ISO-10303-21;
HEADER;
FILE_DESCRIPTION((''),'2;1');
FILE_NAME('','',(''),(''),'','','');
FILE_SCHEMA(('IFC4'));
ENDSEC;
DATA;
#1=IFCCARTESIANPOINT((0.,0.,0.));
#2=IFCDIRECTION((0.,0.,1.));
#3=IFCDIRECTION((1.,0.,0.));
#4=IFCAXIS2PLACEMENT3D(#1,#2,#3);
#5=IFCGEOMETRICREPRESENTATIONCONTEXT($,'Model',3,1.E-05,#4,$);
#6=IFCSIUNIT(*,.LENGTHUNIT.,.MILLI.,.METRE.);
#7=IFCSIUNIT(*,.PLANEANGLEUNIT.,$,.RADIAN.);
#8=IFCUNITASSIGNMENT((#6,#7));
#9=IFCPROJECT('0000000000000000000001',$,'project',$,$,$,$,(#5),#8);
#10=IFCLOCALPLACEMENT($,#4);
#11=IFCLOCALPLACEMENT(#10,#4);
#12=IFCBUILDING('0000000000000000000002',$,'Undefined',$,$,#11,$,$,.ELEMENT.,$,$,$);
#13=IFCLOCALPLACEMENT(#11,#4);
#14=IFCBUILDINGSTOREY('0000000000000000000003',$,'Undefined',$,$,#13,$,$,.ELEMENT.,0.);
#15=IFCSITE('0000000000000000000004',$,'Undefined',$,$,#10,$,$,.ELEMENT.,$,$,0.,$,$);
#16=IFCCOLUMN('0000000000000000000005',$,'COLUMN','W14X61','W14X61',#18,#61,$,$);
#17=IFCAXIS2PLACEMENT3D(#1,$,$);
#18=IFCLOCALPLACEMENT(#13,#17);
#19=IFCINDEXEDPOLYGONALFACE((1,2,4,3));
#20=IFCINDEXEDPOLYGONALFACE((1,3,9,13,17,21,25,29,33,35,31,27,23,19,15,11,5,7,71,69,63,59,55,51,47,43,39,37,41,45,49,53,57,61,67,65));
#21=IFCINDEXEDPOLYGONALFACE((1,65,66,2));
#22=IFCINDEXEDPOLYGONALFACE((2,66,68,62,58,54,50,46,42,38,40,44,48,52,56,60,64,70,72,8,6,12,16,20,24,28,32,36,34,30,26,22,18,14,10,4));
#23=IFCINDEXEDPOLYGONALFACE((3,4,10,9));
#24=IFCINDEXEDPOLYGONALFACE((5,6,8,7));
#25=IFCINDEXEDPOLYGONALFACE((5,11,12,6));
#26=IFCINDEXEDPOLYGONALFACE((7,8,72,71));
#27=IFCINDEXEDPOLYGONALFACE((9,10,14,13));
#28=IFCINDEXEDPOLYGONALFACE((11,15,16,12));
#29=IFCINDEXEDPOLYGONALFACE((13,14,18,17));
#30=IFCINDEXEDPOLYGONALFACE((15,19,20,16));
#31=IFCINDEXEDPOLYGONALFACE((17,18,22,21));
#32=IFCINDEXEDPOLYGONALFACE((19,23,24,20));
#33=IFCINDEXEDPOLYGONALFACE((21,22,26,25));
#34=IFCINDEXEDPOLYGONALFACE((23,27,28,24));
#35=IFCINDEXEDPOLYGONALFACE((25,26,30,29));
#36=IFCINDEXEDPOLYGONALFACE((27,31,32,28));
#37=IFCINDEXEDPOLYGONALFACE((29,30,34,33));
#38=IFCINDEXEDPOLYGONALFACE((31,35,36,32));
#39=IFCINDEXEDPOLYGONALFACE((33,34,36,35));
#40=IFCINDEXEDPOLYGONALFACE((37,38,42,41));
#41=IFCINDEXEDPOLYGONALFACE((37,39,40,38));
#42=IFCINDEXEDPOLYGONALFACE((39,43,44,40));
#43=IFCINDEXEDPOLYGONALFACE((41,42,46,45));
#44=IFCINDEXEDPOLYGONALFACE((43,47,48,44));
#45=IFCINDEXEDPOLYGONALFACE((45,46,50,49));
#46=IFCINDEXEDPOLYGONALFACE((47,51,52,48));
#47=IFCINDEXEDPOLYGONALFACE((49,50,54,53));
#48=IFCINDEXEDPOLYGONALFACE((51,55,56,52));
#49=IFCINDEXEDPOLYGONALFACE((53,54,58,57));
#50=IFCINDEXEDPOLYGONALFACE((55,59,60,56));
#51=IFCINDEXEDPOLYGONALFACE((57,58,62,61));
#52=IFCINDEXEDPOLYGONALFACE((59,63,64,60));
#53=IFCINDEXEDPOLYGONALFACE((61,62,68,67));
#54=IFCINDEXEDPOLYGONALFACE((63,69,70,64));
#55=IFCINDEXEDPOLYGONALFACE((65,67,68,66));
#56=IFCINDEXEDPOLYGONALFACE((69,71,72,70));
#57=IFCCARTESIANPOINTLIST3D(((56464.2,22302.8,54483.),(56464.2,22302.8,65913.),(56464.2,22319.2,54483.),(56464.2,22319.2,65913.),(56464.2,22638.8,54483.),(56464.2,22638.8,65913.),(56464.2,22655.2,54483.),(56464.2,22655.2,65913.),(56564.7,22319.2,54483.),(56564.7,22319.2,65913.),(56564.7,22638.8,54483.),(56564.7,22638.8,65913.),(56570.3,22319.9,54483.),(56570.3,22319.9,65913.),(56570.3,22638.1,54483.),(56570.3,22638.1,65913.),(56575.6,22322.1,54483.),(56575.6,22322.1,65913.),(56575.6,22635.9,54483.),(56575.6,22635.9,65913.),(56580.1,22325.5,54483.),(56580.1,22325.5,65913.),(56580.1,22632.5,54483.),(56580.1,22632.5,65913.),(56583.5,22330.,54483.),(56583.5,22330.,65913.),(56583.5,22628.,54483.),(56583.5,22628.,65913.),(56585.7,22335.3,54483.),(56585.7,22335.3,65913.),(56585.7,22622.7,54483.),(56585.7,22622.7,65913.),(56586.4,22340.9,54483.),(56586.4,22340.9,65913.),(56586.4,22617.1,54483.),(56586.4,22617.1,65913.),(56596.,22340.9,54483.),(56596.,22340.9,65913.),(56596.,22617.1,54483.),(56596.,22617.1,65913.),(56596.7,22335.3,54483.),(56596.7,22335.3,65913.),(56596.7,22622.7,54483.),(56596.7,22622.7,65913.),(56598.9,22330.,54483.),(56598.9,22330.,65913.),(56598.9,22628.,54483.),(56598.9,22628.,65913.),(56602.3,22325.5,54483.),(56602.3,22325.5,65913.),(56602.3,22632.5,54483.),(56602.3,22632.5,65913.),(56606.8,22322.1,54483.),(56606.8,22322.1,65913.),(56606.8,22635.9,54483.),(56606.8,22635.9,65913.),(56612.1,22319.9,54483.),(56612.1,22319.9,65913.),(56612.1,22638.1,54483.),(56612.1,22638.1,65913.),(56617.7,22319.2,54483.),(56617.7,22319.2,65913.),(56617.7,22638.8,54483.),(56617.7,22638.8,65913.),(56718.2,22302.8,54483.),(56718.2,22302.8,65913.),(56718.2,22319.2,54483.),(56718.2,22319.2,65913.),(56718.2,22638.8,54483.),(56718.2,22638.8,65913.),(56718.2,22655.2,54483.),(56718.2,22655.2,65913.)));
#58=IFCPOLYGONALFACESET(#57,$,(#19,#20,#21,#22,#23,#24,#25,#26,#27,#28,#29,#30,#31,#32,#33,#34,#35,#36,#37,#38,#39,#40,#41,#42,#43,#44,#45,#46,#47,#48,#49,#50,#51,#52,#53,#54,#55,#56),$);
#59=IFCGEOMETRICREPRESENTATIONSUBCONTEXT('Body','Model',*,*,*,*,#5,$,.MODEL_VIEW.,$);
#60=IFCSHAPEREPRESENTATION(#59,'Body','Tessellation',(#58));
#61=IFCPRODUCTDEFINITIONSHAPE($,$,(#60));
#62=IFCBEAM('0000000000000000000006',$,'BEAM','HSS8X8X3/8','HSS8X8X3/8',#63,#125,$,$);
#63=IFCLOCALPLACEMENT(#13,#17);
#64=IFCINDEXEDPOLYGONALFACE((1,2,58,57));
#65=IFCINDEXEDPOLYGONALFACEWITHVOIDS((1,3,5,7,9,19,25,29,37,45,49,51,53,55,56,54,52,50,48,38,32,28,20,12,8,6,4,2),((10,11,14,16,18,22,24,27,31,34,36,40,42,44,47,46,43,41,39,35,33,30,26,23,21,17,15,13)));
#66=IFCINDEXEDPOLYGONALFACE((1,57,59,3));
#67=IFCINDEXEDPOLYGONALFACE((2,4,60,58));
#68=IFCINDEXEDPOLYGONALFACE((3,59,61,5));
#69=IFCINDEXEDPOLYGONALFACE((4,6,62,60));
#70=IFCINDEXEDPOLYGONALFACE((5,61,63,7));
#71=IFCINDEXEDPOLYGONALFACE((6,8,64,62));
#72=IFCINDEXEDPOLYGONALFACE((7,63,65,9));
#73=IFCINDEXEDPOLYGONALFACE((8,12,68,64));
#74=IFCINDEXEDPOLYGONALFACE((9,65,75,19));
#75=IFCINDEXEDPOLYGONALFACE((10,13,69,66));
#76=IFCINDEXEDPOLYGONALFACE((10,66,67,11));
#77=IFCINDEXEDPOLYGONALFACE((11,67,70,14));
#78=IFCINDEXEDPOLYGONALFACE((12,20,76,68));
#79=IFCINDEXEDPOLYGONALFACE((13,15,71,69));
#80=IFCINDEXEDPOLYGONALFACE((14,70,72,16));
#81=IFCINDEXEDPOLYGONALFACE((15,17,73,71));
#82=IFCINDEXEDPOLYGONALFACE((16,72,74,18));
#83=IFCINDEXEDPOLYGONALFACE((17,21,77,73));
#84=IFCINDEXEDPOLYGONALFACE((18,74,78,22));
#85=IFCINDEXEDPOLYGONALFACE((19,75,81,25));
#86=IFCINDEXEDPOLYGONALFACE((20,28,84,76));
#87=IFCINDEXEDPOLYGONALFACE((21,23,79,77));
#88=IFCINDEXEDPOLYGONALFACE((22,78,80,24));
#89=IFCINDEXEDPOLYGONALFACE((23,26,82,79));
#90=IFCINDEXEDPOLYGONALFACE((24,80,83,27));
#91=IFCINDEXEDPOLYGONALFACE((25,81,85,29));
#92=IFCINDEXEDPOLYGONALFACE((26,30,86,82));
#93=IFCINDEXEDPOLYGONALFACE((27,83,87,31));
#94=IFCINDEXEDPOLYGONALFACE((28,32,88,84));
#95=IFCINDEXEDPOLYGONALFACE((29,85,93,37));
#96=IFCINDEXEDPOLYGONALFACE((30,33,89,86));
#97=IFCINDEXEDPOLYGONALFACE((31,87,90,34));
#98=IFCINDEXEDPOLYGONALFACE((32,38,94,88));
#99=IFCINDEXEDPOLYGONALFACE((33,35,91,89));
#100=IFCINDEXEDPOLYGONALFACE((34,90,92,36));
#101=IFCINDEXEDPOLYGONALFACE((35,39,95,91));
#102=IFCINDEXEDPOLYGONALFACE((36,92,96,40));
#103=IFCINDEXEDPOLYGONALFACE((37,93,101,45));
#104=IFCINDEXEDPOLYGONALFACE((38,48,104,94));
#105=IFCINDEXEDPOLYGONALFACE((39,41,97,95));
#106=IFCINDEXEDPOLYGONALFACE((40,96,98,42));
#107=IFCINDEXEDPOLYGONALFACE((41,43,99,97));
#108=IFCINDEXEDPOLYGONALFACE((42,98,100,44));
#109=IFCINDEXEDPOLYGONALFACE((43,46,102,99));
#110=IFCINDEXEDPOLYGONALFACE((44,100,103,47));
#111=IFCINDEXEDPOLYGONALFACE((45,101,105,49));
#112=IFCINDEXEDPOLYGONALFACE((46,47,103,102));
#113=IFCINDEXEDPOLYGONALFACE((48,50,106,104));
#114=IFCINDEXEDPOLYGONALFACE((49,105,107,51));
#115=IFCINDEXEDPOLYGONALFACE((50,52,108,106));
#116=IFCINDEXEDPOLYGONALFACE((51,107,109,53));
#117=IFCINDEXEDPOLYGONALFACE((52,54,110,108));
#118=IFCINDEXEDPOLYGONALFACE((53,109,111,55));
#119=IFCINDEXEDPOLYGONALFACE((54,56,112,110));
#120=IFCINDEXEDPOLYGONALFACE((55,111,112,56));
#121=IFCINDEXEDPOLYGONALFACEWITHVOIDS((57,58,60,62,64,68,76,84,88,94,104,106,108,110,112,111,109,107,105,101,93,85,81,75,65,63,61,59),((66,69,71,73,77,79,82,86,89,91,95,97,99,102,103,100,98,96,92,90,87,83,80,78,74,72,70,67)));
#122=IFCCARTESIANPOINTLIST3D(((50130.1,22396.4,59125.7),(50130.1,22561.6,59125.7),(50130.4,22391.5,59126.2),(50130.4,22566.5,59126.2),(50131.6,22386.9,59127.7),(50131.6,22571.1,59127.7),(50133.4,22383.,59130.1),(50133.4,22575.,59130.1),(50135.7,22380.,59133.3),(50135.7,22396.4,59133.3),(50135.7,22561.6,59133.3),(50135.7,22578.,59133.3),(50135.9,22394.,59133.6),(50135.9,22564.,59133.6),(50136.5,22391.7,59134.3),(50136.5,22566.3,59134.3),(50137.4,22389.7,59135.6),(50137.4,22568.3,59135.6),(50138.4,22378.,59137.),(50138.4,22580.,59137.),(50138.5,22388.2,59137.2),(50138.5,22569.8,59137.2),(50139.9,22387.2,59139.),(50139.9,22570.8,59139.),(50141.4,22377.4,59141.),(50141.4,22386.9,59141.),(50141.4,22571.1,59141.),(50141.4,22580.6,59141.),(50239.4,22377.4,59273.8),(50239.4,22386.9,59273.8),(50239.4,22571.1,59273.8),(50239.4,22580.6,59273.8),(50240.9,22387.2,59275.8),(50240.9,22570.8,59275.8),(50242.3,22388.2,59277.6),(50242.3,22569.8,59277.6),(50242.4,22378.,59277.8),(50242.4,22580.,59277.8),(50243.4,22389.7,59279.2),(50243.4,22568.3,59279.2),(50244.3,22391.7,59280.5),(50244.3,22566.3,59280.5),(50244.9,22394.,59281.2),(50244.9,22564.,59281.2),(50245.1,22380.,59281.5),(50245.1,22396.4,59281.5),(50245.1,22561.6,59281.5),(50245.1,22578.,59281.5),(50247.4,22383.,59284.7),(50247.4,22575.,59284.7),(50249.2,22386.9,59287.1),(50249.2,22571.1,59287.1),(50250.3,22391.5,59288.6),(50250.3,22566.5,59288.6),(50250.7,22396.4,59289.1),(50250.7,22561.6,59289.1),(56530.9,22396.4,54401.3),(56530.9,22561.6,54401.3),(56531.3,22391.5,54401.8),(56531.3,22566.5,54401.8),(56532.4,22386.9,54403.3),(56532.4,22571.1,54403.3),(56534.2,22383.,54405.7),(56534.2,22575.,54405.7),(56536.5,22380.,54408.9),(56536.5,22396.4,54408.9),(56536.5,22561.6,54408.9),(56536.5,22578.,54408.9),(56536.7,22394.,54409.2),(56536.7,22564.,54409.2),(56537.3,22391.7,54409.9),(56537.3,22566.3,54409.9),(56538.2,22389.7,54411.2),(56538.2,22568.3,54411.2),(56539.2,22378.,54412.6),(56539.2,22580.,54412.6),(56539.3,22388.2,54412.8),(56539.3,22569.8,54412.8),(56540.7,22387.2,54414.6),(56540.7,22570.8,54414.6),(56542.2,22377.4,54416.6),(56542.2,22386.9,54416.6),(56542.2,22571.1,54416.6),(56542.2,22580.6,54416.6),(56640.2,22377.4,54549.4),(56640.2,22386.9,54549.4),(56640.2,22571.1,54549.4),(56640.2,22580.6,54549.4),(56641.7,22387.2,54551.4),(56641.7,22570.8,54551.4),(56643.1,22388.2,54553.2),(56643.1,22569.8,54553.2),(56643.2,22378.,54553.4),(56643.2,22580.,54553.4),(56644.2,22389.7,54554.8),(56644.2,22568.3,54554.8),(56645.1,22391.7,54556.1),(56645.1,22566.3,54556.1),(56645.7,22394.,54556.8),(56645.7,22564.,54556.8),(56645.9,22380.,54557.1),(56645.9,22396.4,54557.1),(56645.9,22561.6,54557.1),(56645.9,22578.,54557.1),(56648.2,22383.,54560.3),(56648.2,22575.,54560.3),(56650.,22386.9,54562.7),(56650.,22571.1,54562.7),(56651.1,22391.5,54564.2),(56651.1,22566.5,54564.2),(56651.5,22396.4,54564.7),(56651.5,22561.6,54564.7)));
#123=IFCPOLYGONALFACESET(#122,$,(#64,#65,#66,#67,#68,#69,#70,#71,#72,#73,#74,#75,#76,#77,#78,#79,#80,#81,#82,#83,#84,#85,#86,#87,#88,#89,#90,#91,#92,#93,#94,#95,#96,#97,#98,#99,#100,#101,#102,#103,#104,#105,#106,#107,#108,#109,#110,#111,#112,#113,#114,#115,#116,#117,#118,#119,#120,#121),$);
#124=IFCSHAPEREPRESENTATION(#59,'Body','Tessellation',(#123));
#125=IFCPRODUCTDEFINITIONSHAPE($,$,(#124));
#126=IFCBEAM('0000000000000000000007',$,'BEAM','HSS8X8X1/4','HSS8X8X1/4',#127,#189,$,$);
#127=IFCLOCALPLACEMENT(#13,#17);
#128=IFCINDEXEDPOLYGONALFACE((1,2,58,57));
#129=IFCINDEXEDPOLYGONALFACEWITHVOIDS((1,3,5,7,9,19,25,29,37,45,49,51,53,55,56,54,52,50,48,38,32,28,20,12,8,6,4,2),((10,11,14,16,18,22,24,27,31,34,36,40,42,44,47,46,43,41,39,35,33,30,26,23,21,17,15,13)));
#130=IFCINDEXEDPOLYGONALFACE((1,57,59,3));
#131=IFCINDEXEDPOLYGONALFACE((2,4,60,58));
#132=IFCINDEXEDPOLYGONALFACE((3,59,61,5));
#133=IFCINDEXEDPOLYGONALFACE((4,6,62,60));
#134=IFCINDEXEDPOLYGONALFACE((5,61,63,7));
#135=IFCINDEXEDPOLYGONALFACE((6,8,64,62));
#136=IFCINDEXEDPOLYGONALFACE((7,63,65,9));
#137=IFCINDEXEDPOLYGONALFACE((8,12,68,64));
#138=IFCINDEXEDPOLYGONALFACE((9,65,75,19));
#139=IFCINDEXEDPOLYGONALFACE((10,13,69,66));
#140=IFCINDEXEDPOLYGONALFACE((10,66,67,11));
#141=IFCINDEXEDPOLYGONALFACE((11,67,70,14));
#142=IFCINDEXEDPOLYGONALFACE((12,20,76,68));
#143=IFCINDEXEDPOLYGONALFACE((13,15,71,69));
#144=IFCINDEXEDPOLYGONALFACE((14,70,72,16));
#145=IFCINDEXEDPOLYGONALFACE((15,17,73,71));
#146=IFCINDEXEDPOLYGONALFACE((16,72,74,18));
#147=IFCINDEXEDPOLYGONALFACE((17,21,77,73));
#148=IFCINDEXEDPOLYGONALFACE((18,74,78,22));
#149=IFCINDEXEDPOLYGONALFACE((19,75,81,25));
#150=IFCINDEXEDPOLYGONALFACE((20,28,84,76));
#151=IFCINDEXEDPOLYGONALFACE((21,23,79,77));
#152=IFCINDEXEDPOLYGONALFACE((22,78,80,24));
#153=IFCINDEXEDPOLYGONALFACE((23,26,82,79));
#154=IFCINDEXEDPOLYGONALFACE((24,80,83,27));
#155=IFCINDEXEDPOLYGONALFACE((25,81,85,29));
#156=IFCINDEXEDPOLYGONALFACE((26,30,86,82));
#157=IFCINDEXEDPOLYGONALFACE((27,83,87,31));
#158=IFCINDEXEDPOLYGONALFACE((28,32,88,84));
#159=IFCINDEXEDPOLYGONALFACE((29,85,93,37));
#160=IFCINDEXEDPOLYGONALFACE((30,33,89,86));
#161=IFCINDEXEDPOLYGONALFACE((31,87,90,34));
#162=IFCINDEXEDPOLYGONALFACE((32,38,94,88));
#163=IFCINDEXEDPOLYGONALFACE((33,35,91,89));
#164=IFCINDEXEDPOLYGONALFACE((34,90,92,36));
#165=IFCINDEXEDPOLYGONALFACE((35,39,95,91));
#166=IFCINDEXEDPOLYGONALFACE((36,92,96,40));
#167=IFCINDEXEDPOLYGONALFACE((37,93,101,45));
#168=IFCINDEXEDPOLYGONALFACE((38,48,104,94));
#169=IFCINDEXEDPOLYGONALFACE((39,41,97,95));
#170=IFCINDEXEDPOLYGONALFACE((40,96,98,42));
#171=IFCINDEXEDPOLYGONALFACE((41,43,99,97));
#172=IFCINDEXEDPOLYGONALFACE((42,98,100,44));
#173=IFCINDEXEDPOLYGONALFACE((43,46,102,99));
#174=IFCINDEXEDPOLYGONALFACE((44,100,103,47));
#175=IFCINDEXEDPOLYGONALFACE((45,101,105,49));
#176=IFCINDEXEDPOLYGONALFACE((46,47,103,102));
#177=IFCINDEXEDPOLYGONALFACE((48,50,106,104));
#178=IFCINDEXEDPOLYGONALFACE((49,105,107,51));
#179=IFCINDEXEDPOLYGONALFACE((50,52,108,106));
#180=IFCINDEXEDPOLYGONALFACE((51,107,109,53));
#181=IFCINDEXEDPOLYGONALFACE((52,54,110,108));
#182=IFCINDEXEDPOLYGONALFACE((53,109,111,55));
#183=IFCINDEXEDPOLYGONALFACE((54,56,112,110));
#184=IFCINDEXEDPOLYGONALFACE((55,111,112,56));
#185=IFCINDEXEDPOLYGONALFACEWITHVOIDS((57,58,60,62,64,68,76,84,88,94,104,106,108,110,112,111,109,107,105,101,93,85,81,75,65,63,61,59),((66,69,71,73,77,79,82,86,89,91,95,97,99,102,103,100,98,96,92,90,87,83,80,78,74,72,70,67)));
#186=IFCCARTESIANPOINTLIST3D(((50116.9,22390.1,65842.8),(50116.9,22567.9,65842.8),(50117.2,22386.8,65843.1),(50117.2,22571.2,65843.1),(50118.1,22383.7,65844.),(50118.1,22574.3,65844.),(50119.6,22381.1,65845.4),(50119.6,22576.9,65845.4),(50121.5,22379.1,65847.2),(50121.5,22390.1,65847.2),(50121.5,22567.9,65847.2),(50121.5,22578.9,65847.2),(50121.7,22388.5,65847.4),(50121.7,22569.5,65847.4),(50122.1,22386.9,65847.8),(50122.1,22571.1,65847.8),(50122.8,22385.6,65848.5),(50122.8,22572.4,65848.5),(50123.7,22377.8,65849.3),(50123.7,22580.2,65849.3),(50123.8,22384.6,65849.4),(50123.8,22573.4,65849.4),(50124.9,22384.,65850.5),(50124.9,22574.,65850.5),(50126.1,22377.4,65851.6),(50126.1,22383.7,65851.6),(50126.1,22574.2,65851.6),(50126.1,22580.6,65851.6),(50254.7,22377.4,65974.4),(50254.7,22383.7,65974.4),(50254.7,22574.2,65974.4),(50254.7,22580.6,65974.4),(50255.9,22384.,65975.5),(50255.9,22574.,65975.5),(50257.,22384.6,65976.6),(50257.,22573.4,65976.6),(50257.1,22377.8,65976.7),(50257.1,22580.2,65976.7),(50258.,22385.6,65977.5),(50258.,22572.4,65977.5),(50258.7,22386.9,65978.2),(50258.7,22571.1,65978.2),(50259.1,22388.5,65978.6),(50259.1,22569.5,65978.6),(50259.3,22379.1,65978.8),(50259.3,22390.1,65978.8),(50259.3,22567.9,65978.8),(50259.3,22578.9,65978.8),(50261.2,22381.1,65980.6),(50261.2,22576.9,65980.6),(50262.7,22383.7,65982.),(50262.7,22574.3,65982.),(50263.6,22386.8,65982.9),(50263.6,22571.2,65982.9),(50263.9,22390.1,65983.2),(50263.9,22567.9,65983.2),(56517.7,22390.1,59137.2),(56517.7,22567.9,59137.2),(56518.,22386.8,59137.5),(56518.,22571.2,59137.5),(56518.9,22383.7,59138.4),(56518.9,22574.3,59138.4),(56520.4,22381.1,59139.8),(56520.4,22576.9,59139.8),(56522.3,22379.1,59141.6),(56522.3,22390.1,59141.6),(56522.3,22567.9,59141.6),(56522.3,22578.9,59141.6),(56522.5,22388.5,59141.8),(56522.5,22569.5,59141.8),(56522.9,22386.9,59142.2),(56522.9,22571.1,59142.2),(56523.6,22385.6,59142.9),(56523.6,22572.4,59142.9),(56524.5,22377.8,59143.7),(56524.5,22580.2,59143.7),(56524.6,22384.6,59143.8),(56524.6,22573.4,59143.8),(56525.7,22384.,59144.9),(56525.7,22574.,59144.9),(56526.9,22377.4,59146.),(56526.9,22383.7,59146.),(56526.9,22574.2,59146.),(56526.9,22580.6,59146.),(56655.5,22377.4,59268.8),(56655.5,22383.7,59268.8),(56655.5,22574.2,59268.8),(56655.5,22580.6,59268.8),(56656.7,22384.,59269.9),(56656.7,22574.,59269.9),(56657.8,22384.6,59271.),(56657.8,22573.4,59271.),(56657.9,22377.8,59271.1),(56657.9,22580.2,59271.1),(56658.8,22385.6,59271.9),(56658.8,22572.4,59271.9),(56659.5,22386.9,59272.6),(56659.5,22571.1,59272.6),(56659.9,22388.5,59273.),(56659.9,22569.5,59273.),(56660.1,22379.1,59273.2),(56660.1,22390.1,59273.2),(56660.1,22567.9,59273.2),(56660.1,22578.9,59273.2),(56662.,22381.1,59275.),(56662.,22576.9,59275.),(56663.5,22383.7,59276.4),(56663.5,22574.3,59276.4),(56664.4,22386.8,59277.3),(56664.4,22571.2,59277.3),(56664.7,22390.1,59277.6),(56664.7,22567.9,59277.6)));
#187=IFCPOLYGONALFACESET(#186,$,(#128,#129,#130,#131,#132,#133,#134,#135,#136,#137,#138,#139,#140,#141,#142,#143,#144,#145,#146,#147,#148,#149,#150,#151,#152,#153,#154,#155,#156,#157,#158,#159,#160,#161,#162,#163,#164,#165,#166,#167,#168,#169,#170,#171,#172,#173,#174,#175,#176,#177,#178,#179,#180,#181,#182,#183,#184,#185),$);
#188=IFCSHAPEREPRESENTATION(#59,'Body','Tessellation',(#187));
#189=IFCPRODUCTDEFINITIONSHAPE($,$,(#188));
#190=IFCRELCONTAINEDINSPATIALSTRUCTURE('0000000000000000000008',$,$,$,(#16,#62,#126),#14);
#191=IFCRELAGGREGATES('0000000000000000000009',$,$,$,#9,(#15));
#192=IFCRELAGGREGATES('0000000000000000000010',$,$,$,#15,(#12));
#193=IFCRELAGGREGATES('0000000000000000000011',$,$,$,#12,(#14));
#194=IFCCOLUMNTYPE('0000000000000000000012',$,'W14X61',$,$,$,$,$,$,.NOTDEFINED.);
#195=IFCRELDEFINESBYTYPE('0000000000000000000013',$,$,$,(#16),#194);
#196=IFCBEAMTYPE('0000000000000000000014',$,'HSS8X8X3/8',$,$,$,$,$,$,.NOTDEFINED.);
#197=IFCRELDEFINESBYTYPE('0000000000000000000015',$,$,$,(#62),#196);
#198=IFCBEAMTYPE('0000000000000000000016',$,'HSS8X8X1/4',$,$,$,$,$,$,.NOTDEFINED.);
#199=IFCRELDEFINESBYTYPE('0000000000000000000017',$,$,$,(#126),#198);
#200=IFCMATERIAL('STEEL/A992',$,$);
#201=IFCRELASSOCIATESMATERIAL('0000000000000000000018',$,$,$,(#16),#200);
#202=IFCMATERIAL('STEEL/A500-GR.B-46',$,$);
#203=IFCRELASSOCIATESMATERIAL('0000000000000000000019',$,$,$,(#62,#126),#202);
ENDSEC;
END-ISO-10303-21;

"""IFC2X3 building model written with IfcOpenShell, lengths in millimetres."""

from ifc_helpers import new_model, si_unit, frame, origin_with_axes, origin_2d_with_axis, place, context, subcontext, project, spatial, hollow_rectangle, i_section, extrude, material, type_object, element, save


model = new_model("IFC2X3")

# Units and contexts
model_context = context("Model", 3, precision=1e-05, world=origin_with_axes())
body_context = subcontext(model_context, "Body", "Model", "MODEL_VIEW")
ifc_project = project(units=[si_unit("LENGTHUNIT", "METRE", prefix="MILLI"), si_unit("PLANEANGLEUNIT", "RADIAN")], contexts=[model_context])

# Site, building, storey
site_placement = place(None, origin_with_axes())
site = spatial("IfcSite", under=ifc_project, at=site_placement, Name="Undefined", CompositionType="ELEMENT", RefElevation=0.0)
building_placement = place(site_placement, origin_with_axes())
building = spatial("IfcBuilding", under=site, at=building_placement, Name="Undefined", CompositionType="ELEMENT")
storey_placement = place(building_placement, origin_with_axes())
storey = spatial("IfcBuildingStorey", under=building, at=storey_placement, Name="Undefined", CompositionType="ELEMENT", Elevation=0.0)

# Column
ifc_material_1 = material(Name="STEEL/A992")
column_type = type_object("IfcColumnType", Name="W14X61", PredefinedType="NOTDEFINED")
column_placement = place(storey_placement, frame((56591.2, 22479.0, 54483.0), z_axis=(0.0, 0.0, 1.0), x_axis=(1.0, 0.0, 0.0)))
element("IfcColumn", 1, at=column_placement, inside=storey, type_object=column_type, material=ifc_material_1, Name="COLUMN", Description="W14X61", ObjectType="W14X61", context=body_context, shape_type="SweptSolid", body=[
    extrude(i_section(OverallWidth=254.0, OverallDepth=352.4, WebThickness=9.5, FlangeThickness=16.4, FilletRadius=21.7, at=origin_2d_with_axis()), frame((0.0, 0.0, 11430.0), z_axis=(0.0, 0.0, -1.0), x_axis=(-1.0, 0.0, 0.0)), (0.0, 0.0, 1.0), 11430.0),
])

# Beams
ifc_material_2 = material(Name="STEEL/A500-GR.B-46")
beam_type_1 = type_object("IfcBeamType", Name="HSS8X8X3/8", PredefinedType="NOTDEFINED")
beam_1_placement = place(storey_placement, frame((56591.2, 22479.0, 54483.0), z_axis=(0.593852, 0.0, 0.804574), x_axis=(-0.804574, 0.0, 0.593852)))
element("IfcBeam", 2, at=beam_1_placement, inside=storey, type_object=beam_type_1, material=ifc_material_2, Name="BEAM", Description="HSS8X8X3/8", ObjectType="HSS8X8X3/8", context=body_context, shape_type="SweptSolid", body=[
    extrude(hollow_rectangle(XDim=203.2, YDim=203.2, WallThickness=9.5, InnerFilletRadius=9.5, OuterFilletRadius=19.0, at=origin_2d_with_axis()), frame((7955.5, 0.0, 0.0), z_axis=(-1.0, 0.0, 0.0), x_axis=(0.0, -1.0, 0.0)), (0.0, 0.0, 1.0), 7955.5),
])
beam_type_2 = type_object("IfcBeamType", Name="HSS8X8X1/4", PredefinedType="NOTDEFINED")
beam_2_placement = place(storey_placement, frame((56591.2, 22479.0, 59207.4), z_axis=(0.723356, 0.0, 0.690476), x_axis=(-0.690476, 0.0, 0.723356)))
element("IfcBeam", 3, at=beam_2_placement, inside=storey, type_object=beam_type_2, material=ifc_material_2, Name="BEAM", Description="HSS8X8X1/4", ObjectType="HSS8X8X1/4", context=body_context, shape_type="SweptSolid", body=[
    extrude(hollow_rectangle(XDim=203.2, YDim=203.2, WallThickness=6.3, InnerFilletRadius=6.3, OuterFilletRadius=12.7, at=origin_2d_with_axis()), frame((9270.1, 0.0, 0.0), z_axis=(-1.0, 0.0, 0.0), x_axis=(0.0, -1.0, 0.0)), (0.0, 0.0, 1.0), 9270.1),
])

save(model, "model.ifc")
